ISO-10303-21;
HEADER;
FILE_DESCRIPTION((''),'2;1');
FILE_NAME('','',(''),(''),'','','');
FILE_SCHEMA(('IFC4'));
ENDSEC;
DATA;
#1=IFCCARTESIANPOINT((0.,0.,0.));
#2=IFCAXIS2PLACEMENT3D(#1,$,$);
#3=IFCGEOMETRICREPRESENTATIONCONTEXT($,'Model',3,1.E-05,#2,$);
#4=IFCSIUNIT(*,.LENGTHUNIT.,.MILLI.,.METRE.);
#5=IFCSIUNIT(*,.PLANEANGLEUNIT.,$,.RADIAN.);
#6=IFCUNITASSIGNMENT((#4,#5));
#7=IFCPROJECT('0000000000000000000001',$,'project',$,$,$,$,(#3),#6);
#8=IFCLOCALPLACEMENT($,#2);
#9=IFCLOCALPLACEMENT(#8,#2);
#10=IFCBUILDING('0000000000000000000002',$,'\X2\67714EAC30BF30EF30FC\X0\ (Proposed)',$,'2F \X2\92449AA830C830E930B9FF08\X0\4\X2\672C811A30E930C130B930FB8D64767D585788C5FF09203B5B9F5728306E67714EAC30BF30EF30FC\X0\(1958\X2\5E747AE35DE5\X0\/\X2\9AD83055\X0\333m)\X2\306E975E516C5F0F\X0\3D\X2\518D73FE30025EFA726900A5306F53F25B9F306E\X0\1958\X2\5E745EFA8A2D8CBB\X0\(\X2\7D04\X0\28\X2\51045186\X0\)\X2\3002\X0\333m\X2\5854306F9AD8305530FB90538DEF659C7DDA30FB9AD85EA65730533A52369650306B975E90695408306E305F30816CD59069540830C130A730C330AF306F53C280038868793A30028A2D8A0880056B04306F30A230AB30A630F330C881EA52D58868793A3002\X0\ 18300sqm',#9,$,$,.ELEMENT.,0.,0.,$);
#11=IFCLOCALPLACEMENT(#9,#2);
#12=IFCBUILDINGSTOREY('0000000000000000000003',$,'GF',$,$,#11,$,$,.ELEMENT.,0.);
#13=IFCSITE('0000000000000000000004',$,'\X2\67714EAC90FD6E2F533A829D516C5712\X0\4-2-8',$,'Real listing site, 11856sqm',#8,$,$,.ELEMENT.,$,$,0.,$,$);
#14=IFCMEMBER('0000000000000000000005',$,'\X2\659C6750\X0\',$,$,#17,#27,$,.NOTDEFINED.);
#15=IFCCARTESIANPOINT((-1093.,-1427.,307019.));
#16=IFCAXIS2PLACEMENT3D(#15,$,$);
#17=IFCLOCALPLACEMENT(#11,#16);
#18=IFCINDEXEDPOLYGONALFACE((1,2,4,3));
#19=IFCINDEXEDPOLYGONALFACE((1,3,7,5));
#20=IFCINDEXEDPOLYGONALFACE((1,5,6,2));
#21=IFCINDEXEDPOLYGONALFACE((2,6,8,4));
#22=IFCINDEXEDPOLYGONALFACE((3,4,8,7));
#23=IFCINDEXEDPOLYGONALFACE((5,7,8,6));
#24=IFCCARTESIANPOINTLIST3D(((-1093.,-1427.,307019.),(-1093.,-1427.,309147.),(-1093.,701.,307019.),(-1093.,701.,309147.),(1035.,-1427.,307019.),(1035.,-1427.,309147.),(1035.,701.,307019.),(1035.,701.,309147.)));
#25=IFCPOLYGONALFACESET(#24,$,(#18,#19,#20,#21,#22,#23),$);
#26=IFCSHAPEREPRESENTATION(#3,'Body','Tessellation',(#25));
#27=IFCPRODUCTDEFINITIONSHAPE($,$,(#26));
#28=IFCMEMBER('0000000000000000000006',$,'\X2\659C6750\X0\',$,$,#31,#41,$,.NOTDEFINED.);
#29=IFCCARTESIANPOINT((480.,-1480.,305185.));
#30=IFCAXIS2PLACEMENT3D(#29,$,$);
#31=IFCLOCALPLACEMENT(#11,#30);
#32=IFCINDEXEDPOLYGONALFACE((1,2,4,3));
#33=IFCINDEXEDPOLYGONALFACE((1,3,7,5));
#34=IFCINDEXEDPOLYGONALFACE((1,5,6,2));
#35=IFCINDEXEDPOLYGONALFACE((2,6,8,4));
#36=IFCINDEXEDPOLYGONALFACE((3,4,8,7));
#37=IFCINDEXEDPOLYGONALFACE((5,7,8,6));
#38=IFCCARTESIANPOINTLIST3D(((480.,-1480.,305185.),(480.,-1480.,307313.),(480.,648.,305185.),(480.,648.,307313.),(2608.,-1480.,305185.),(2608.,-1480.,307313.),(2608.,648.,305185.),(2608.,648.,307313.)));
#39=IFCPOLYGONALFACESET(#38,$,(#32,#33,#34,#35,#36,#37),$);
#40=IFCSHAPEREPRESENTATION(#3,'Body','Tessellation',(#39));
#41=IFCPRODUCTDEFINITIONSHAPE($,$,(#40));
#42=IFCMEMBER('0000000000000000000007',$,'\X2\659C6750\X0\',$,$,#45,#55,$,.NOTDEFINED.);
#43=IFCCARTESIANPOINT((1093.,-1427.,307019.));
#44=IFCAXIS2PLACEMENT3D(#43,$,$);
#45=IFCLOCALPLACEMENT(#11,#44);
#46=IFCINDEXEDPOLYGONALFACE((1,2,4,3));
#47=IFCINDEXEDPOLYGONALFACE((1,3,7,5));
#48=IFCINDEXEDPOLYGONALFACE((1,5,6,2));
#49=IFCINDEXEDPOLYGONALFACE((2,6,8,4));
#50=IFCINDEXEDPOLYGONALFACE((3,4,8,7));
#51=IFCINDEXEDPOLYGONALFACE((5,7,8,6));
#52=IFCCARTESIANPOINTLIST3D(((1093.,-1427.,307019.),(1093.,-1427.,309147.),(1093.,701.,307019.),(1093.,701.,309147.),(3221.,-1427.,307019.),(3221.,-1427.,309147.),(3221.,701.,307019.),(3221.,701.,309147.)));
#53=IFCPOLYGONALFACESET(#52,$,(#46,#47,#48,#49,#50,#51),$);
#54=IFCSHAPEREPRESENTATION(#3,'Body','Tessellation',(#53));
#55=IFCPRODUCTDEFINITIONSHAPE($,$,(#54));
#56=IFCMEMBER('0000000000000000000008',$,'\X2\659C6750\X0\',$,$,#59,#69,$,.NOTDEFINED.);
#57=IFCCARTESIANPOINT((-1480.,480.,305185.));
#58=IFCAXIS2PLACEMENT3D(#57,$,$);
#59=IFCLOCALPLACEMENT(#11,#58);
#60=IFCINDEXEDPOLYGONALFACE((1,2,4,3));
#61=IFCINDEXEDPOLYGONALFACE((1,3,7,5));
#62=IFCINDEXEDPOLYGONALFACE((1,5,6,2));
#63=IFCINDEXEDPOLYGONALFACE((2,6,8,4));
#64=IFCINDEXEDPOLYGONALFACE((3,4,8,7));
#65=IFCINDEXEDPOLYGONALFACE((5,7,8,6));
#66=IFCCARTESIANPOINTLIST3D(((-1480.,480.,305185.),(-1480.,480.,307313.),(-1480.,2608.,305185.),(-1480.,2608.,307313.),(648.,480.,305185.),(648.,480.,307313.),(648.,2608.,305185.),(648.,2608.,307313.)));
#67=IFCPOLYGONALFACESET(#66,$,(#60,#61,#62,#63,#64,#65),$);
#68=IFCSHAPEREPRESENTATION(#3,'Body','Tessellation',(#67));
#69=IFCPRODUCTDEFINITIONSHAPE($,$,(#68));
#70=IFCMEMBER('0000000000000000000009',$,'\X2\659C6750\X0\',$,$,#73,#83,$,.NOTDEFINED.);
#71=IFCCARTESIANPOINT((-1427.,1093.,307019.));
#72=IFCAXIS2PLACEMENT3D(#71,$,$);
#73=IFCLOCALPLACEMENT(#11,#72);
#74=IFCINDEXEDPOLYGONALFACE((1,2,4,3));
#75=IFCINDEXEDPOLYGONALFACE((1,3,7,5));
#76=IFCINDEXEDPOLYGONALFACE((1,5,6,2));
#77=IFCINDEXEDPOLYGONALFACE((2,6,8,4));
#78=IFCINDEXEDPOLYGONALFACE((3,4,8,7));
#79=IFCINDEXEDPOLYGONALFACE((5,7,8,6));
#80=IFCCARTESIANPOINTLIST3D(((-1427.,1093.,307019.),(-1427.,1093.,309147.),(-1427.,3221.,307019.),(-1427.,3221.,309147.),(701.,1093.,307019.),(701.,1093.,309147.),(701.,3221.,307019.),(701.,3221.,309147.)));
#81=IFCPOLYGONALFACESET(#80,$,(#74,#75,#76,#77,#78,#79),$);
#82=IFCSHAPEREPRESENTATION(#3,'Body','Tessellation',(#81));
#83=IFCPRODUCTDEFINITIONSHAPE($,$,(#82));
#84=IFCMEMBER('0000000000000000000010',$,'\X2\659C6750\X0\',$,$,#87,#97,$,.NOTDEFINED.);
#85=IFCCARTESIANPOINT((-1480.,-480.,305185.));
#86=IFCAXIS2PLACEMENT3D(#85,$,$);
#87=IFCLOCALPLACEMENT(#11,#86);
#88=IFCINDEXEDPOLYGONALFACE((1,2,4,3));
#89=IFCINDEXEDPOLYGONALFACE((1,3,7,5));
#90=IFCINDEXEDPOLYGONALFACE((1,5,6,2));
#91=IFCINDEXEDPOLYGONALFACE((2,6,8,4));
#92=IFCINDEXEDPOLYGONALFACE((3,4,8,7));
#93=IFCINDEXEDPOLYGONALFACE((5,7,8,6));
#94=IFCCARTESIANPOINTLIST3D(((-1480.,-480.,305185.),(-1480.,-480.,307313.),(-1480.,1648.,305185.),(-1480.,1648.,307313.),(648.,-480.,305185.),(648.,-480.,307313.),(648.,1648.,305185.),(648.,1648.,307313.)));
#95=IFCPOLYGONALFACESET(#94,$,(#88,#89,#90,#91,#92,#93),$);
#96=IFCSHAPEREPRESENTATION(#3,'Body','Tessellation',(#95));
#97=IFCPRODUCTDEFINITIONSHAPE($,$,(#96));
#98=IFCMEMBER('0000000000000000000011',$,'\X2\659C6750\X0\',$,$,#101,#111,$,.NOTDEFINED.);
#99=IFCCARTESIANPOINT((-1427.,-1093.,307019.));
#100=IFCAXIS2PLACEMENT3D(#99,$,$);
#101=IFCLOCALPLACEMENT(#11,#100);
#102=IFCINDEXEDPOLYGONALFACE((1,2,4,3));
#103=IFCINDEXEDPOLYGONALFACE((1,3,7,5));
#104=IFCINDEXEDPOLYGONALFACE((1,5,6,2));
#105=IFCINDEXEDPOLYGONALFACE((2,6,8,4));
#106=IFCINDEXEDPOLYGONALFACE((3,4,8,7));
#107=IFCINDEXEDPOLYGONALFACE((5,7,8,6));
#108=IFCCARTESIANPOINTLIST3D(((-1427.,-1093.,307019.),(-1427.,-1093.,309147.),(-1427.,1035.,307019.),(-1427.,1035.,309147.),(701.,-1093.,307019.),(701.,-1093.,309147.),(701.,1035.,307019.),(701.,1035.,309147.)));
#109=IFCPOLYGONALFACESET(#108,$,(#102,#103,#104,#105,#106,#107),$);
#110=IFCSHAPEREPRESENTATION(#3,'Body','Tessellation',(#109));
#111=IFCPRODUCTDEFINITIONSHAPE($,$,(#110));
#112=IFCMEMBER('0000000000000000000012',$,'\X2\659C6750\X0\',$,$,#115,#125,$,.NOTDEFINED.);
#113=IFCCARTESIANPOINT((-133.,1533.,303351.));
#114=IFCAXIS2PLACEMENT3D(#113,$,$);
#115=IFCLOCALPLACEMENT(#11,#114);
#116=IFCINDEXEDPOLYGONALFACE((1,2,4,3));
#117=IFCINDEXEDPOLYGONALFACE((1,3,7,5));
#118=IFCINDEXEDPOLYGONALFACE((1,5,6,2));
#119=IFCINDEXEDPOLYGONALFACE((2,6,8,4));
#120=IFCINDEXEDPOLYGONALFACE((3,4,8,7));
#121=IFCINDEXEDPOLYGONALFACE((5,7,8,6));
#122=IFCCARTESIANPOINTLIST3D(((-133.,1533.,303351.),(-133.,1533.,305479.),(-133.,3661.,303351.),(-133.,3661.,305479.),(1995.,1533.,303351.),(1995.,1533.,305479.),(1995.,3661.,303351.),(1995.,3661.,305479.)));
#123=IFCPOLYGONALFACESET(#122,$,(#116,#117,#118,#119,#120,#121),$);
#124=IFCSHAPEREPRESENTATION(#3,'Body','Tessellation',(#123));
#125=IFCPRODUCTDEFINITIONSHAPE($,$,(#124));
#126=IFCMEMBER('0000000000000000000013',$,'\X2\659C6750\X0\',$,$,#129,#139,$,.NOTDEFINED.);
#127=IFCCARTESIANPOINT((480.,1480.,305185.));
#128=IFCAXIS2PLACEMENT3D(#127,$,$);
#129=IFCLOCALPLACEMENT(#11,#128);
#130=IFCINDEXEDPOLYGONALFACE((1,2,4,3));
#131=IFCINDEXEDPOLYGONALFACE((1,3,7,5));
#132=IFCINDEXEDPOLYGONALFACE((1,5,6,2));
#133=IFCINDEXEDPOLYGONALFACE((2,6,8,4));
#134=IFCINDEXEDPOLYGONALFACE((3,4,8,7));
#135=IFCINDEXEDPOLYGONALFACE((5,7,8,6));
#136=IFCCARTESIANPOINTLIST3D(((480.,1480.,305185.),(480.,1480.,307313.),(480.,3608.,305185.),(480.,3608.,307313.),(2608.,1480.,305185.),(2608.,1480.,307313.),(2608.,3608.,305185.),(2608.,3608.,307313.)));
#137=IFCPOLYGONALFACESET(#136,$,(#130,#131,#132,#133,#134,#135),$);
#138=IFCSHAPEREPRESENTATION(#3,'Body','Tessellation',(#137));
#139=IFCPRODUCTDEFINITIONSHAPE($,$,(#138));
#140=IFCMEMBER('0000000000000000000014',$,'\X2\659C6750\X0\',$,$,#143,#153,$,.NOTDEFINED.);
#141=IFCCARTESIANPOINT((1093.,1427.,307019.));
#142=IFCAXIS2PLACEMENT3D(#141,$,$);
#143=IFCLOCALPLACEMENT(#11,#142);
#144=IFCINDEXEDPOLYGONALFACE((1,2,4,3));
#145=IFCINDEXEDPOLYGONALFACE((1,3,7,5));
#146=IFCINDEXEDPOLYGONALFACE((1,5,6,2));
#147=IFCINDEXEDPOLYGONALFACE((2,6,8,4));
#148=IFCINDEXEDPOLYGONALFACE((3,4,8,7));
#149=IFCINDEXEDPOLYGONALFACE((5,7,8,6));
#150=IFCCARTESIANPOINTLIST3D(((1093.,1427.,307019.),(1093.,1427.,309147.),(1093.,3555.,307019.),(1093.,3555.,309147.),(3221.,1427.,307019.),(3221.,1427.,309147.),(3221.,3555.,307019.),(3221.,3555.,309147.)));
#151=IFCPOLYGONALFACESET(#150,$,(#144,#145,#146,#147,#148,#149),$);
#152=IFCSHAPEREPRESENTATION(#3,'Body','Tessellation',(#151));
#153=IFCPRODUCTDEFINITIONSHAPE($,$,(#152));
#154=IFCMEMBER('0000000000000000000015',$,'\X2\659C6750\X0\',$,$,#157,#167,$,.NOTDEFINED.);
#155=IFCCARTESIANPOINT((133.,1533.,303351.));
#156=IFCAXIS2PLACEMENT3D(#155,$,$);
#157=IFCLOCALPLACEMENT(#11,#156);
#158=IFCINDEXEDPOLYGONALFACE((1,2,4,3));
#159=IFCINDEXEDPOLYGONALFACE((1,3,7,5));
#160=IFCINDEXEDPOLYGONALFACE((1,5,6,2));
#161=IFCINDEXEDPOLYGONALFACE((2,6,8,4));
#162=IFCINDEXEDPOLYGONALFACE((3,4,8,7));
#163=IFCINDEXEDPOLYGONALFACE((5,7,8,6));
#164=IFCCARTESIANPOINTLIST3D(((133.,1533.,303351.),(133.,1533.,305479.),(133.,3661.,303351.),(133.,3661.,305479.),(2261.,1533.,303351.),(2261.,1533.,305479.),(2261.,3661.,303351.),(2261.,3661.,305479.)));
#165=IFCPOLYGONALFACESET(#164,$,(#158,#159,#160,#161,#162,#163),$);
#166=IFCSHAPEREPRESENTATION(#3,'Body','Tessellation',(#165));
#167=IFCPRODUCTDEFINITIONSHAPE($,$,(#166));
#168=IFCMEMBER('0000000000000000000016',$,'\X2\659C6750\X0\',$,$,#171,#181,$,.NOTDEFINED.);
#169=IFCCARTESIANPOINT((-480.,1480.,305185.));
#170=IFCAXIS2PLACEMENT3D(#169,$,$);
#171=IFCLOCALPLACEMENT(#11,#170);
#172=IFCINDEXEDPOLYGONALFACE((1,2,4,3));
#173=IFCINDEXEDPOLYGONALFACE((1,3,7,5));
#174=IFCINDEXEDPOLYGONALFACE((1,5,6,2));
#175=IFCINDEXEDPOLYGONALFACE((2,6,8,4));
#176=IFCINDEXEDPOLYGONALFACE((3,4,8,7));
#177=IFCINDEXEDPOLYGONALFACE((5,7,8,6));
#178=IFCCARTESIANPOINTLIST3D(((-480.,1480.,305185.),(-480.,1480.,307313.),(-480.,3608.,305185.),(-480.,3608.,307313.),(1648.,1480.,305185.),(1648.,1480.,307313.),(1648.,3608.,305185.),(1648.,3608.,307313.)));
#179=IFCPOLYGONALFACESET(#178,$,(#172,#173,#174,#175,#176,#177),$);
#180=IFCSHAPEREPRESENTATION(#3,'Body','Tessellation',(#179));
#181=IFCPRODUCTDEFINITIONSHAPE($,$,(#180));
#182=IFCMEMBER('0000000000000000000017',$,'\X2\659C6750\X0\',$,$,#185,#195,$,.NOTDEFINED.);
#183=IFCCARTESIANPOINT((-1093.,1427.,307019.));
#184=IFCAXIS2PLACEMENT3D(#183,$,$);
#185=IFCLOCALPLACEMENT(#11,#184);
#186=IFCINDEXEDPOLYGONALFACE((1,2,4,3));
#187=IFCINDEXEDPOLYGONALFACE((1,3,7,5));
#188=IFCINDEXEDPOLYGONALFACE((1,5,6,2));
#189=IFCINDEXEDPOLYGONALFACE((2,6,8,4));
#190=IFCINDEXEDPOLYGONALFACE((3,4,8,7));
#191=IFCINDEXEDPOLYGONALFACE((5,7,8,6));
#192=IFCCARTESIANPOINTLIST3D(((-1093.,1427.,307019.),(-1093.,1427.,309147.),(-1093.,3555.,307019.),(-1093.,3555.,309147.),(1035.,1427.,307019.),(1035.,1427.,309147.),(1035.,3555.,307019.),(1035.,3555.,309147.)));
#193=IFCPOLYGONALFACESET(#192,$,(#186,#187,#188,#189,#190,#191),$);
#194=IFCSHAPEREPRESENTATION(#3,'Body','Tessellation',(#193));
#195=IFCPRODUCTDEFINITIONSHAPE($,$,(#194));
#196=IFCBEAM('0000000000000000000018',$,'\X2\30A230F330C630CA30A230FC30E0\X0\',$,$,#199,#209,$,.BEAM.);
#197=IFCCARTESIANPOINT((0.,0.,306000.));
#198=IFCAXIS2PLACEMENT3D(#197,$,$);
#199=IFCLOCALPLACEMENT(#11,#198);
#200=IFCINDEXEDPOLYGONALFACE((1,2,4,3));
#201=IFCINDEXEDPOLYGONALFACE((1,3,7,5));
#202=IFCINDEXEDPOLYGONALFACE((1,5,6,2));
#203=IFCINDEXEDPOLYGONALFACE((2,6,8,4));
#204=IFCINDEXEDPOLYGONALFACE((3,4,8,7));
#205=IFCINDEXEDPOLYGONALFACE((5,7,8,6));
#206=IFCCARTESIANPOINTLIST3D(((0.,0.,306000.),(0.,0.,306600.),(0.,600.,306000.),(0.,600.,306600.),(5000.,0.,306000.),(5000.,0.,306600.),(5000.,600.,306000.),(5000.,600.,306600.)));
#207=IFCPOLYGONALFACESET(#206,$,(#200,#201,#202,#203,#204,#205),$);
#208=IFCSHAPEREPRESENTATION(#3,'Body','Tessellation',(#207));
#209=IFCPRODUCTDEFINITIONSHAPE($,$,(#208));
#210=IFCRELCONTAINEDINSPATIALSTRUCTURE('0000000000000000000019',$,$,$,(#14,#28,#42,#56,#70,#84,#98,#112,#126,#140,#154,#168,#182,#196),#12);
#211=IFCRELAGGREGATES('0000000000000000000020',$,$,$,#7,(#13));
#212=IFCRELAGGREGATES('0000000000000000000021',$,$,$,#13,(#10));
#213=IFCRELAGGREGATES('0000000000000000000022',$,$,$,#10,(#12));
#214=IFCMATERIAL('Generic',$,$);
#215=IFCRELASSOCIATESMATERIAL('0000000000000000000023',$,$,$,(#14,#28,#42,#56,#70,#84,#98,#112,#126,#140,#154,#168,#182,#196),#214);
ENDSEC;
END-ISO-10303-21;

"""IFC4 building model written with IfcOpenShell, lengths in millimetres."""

from ifc_helpers import new_model, si_unit, frame, frame_2d, origin, place, context, project, spatial, rectangle, extrude, material, element, save


model = new_model("IFC4")

# Units and contexts
model_context = context("Model", 3, precision=1e-05, world=origin())
ifc_project = project(units=[si_unit("LENGTHUNIT", "METRE", prefix="MILLI"), si_unit("PLANEANGLEUNIT", "RADIAN")], contexts=[model_context])

# Site, building, storey
site_placement = place(None, origin())
site = spatial("IfcSite", under=ifc_project, at=site_placement, Name="東京都港区芝公園4-2-8", ObjectType="Real listing site, 11856sqm", CompositionType="ELEMENT", RefElevation=0.0)
building_placement = place(site_placement, origin())
building = spatial("IfcBuilding", under=site, at=building_placement, Name="東京タワー (Proposed)", ObjectType="2F 鉄骨トラス（4本脚ラチス・赤白塗装）※実在の東京タワー(1958年竣工/高さ333m)の非公式3D再現。建物¥は史実の1958年建設費(約28億円)。333m塔は高さ・道路斜線・高度地区制限に非適合のため法適合チェックは参考表示。設計者欄はアカウント自動表示。 18300sqm", CompositionType="ELEMENT", ElevationOfRefHeight=0.0, ElevationOfTerrain=0.0)
storey_placement = place(building_placement, origin())
storey = spatial("IfcBuildingStorey", under=building, at=storey_placement, Name="GF", CompositionType="ELEMENT", Elevation=0.0)

# Shared definitions
ifc_material = material(Name="Generic")

# Members
member_1_placement = place(storey_placement, frame((-1093.0, -1427.0, 307019.0)))
element("IfcMember", 1, at=member_1_placement, inside=storey, material=ifc_material, Name="斜材", PredefinedType="NOTDEFINED", context=model_context, shape_type="SweptSolid", body=[
    extrude(rectangle(XDim=2128.0, YDim=2128.0, at=frame_2d((1064.0, 1064.0))), frame((-1093.0, -1427.0, 307019.0)), (0.0, 0.0, 1.0), 2128.0),
])
member_2_placement = place(storey_placement, frame((480.0, -1480.0, 305185.0)))
element("IfcMember", 2, at=member_2_placement, inside=storey, material=ifc_material, Name="斜材", PredefinedType="NOTDEFINED", context=model_context, shape_type="SweptSolid", body=[
    extrude(rectangle(XDim=2128.0, YDim=2128.0, at=frame_2d((1064.0, 1064.0))), frame((480.0, -1480.0, 305185.0)), (0.0, 0.0, 1.0), 2128.0),
])
member_3_placement = place(storey_placement, frame((1093.0, -1427.0, 307019.0)))
element("IfcMember", 3, at=member_3_placement, inside=storey, material=ifc_material, Name="斜材", PredefinedType="NOTDEFINED", context=model_context, shape_type="SweptSolid", body=[
    extrude(rectangle(XDim=2128.0, YDim=2128.0, at=frame_2d((1064.0, 1064.0))), frame((1093.0, -1427.0, 307019.0)), (0.0, 0.0, 1.0), 2128.0),
])
member_4_placement = place(storey_placement, frame((-1480.0, 480.0, 305185.0)))
element("IfcMember", 4, at=member_4_placement, inside=storey, material=ifc_material, Name="斜材", PredefinedType="NOTDEFINED", context=model_context, shape_type="SweptSolid", body=[
    extrude(rectangle(XDim=2128.0, YDim=2128.0, at=frame_2d((1064.0, 1064.0))), frame((-1480.0, 480.0, 305185.0)), (0.0, 0.0, 1.0), 2128.0),
])
member_5_placement = place(storey_placement, frame((-1427.0, 1093.0, 307019.0)))
element("IfcMember", 5, at=member_5_placement, inside=storey, material=ifc_material, Name="斜材", PredefinedType="NOTDEFINED", context=model_context, shape_type="SweptSolid", body=[
    extrude(rectangle(XDim=2128.0, YDim=2128.0, at=frame_2d((1064.0, 1064.0))), frame((-1427.0, 1093.0, 307019.0)), (0.0, 0.0, 1.0), 2128.0),
])
member_6_placement = place(storey_placement, frame((-1480.0, -480.0, 305185.0)))
element("IfcMember", 6, at=member_6_placement, inside=storey, material=ifc_material, Name="斜材", PredefinedType="NOTDEFINED", context=model_context, shape_type="SweptSolid", body=[
    extrude(rectangle(XDim=2128.0, YDim=2128.0, at=frame_2d((1064.0, 1064.0))), frame((-1480.0, -480.0, 305185.0)), (0.0, 0.0, 1.0), 2128.0),
])
member_7_placement = place(storey_placement, frame((-1427.0, -1093.0, 307019.0)))
element("IfcMember", 7, at=member_7_placement, inside=storey, material=ifc_material, Name="斜材", PredefinedType="NOTDEFINED", context=model_context, shape_type="SweptSolid", body=[
    extrude(rectangle(XDim=2128.0, YDim=2128.0, at=frame_2d((1064.0, 1064.0))), frame((-1427.0, -1093.0, 307019.0)), (0.0, 0.0, 1.0), 2128.0),
])
member_8_placement = place(storey_placement, frame((-133.0, 1533.0, 303351.0)))
element("IfcMember", 8, at=member_8_placement, inside=storey, material=ifc_material, Name="斜材", PredefinedType="NOTDEFINED", context=model_context, shape_type="SweptSolid", body=[
    extrude(rectangle(XDim=2128.0, YDim=2128.0, at=frame_2d((1064.0, 1064.0))), frame((-133.0, 1533.0, 303351.0)), (0.0, 0.0, 1.0), 2128.0),
])
member_9_placement = place(storey_placement, frame((480.0, 1480.0, 305185.0)))
element("IfcMember", 9, at=member_9_placement, inside=storey, material=ifc_material, Name="斜材", PredefinedType="NOTDEFINED", context=model_context, shape_type="SweptSolid", body=[
    extrude(rectangle(XDim=2128.0, YDim=2128.0, at=frame_2d((1064.0, 1064.0))), frame((480.0, 1480.0, 305185.0)), (0.0, 0.0, 1.0), 2128.0),
])
member_10_placement = place(storey_placement, frame((1093.0, 1427.0, 307019.0)))
element("IfcMember", 10, at=member_10_placement, inside=storey, material=ifc_material, Name="斜材", PredefinedType="NOTDEFINED", context=model_context, shape_type="SweptSolid", body=[
    extrude(rectangle(XDim=2128.0, YDim=2128.0, at=frame_2d((1064.0, 1064.0))), frame((1093.0, 1427.0, 307019.0)), (0.0, 0.0, 1.0), 2128.0),
])
member_11_placement = place(storey_placement, frame((133.0, 1533.0, 303351.0)))
element("IfcMember", 11, at=member_11_placement, inside=storey, material=ifc_material, Name="斜材", PredefinedType="NOTDEFINED", context=model_context, shape_type="SweptSolid", body=[
    extrude(rectangle(XDim=2128.0, YDim=2128.0, at=frame_2d((1064.0, 1064.0))), frame((133.0, 1533.0, 303351.0)), (0.0, 0.0, 1.0), 2128.0),
])
member_12_placement = place(storey_placement, frame((-480.0, 1480.0, 305185.0)))
element("IfcMember", 12, at=member_12_placement, inside=storey, material=ifc_material, Name="斜材", PredefinedType="NOTDEFINED", context=model_context, shape_type="SweptSolid", body=[
    extrude(rectangle(XDim=2128.0, YDim=2128.0, at=frame_2d((1064.0, 1064.0))), frame((-480.0, 1480.0, 305185.0)), (0.0, 0.0, 1.0), 2128.0),
])
member_13_placement = place(storey_placement, frame((-1093.0, 1427.0, 307019.0)))
element("IfcMember", 13, at=member_13_placement, inside=storey, material=ifc_material, Name="斜材", PredefinedType="NOTDEFINED", context=model_context, shape_type="SweptSolid", body=[
    extrude(rectangle(XDim=2128.0, YDim=2128.0, at=frame_2d((1064.0, 1064.0))), frame((-1093.0, 1427.0, 307019.0)), (0.0, 0.0, 1.0), 2128.0),
])

# Beam
beam_1_placement = place(storey_placement, frame((0.0, 0.0, 306000.0)))
element("IfcBeam", 14, at=beam_1_placement, inside=storey, material=ifc_material, Name="アンテナアーム", PredefinedType="BEAM", context=model_context, shape_type="SweptSolid", body=[
    extrude(rectangle(XDim=5000.0, YDim=600.0, at=frame_2d((2500.0, 300.0))), frame((0.0, 0.0, 306000.0)), (0.0, 0.0, 1.0), 600.0),
])

save(model, "model.ifc")
